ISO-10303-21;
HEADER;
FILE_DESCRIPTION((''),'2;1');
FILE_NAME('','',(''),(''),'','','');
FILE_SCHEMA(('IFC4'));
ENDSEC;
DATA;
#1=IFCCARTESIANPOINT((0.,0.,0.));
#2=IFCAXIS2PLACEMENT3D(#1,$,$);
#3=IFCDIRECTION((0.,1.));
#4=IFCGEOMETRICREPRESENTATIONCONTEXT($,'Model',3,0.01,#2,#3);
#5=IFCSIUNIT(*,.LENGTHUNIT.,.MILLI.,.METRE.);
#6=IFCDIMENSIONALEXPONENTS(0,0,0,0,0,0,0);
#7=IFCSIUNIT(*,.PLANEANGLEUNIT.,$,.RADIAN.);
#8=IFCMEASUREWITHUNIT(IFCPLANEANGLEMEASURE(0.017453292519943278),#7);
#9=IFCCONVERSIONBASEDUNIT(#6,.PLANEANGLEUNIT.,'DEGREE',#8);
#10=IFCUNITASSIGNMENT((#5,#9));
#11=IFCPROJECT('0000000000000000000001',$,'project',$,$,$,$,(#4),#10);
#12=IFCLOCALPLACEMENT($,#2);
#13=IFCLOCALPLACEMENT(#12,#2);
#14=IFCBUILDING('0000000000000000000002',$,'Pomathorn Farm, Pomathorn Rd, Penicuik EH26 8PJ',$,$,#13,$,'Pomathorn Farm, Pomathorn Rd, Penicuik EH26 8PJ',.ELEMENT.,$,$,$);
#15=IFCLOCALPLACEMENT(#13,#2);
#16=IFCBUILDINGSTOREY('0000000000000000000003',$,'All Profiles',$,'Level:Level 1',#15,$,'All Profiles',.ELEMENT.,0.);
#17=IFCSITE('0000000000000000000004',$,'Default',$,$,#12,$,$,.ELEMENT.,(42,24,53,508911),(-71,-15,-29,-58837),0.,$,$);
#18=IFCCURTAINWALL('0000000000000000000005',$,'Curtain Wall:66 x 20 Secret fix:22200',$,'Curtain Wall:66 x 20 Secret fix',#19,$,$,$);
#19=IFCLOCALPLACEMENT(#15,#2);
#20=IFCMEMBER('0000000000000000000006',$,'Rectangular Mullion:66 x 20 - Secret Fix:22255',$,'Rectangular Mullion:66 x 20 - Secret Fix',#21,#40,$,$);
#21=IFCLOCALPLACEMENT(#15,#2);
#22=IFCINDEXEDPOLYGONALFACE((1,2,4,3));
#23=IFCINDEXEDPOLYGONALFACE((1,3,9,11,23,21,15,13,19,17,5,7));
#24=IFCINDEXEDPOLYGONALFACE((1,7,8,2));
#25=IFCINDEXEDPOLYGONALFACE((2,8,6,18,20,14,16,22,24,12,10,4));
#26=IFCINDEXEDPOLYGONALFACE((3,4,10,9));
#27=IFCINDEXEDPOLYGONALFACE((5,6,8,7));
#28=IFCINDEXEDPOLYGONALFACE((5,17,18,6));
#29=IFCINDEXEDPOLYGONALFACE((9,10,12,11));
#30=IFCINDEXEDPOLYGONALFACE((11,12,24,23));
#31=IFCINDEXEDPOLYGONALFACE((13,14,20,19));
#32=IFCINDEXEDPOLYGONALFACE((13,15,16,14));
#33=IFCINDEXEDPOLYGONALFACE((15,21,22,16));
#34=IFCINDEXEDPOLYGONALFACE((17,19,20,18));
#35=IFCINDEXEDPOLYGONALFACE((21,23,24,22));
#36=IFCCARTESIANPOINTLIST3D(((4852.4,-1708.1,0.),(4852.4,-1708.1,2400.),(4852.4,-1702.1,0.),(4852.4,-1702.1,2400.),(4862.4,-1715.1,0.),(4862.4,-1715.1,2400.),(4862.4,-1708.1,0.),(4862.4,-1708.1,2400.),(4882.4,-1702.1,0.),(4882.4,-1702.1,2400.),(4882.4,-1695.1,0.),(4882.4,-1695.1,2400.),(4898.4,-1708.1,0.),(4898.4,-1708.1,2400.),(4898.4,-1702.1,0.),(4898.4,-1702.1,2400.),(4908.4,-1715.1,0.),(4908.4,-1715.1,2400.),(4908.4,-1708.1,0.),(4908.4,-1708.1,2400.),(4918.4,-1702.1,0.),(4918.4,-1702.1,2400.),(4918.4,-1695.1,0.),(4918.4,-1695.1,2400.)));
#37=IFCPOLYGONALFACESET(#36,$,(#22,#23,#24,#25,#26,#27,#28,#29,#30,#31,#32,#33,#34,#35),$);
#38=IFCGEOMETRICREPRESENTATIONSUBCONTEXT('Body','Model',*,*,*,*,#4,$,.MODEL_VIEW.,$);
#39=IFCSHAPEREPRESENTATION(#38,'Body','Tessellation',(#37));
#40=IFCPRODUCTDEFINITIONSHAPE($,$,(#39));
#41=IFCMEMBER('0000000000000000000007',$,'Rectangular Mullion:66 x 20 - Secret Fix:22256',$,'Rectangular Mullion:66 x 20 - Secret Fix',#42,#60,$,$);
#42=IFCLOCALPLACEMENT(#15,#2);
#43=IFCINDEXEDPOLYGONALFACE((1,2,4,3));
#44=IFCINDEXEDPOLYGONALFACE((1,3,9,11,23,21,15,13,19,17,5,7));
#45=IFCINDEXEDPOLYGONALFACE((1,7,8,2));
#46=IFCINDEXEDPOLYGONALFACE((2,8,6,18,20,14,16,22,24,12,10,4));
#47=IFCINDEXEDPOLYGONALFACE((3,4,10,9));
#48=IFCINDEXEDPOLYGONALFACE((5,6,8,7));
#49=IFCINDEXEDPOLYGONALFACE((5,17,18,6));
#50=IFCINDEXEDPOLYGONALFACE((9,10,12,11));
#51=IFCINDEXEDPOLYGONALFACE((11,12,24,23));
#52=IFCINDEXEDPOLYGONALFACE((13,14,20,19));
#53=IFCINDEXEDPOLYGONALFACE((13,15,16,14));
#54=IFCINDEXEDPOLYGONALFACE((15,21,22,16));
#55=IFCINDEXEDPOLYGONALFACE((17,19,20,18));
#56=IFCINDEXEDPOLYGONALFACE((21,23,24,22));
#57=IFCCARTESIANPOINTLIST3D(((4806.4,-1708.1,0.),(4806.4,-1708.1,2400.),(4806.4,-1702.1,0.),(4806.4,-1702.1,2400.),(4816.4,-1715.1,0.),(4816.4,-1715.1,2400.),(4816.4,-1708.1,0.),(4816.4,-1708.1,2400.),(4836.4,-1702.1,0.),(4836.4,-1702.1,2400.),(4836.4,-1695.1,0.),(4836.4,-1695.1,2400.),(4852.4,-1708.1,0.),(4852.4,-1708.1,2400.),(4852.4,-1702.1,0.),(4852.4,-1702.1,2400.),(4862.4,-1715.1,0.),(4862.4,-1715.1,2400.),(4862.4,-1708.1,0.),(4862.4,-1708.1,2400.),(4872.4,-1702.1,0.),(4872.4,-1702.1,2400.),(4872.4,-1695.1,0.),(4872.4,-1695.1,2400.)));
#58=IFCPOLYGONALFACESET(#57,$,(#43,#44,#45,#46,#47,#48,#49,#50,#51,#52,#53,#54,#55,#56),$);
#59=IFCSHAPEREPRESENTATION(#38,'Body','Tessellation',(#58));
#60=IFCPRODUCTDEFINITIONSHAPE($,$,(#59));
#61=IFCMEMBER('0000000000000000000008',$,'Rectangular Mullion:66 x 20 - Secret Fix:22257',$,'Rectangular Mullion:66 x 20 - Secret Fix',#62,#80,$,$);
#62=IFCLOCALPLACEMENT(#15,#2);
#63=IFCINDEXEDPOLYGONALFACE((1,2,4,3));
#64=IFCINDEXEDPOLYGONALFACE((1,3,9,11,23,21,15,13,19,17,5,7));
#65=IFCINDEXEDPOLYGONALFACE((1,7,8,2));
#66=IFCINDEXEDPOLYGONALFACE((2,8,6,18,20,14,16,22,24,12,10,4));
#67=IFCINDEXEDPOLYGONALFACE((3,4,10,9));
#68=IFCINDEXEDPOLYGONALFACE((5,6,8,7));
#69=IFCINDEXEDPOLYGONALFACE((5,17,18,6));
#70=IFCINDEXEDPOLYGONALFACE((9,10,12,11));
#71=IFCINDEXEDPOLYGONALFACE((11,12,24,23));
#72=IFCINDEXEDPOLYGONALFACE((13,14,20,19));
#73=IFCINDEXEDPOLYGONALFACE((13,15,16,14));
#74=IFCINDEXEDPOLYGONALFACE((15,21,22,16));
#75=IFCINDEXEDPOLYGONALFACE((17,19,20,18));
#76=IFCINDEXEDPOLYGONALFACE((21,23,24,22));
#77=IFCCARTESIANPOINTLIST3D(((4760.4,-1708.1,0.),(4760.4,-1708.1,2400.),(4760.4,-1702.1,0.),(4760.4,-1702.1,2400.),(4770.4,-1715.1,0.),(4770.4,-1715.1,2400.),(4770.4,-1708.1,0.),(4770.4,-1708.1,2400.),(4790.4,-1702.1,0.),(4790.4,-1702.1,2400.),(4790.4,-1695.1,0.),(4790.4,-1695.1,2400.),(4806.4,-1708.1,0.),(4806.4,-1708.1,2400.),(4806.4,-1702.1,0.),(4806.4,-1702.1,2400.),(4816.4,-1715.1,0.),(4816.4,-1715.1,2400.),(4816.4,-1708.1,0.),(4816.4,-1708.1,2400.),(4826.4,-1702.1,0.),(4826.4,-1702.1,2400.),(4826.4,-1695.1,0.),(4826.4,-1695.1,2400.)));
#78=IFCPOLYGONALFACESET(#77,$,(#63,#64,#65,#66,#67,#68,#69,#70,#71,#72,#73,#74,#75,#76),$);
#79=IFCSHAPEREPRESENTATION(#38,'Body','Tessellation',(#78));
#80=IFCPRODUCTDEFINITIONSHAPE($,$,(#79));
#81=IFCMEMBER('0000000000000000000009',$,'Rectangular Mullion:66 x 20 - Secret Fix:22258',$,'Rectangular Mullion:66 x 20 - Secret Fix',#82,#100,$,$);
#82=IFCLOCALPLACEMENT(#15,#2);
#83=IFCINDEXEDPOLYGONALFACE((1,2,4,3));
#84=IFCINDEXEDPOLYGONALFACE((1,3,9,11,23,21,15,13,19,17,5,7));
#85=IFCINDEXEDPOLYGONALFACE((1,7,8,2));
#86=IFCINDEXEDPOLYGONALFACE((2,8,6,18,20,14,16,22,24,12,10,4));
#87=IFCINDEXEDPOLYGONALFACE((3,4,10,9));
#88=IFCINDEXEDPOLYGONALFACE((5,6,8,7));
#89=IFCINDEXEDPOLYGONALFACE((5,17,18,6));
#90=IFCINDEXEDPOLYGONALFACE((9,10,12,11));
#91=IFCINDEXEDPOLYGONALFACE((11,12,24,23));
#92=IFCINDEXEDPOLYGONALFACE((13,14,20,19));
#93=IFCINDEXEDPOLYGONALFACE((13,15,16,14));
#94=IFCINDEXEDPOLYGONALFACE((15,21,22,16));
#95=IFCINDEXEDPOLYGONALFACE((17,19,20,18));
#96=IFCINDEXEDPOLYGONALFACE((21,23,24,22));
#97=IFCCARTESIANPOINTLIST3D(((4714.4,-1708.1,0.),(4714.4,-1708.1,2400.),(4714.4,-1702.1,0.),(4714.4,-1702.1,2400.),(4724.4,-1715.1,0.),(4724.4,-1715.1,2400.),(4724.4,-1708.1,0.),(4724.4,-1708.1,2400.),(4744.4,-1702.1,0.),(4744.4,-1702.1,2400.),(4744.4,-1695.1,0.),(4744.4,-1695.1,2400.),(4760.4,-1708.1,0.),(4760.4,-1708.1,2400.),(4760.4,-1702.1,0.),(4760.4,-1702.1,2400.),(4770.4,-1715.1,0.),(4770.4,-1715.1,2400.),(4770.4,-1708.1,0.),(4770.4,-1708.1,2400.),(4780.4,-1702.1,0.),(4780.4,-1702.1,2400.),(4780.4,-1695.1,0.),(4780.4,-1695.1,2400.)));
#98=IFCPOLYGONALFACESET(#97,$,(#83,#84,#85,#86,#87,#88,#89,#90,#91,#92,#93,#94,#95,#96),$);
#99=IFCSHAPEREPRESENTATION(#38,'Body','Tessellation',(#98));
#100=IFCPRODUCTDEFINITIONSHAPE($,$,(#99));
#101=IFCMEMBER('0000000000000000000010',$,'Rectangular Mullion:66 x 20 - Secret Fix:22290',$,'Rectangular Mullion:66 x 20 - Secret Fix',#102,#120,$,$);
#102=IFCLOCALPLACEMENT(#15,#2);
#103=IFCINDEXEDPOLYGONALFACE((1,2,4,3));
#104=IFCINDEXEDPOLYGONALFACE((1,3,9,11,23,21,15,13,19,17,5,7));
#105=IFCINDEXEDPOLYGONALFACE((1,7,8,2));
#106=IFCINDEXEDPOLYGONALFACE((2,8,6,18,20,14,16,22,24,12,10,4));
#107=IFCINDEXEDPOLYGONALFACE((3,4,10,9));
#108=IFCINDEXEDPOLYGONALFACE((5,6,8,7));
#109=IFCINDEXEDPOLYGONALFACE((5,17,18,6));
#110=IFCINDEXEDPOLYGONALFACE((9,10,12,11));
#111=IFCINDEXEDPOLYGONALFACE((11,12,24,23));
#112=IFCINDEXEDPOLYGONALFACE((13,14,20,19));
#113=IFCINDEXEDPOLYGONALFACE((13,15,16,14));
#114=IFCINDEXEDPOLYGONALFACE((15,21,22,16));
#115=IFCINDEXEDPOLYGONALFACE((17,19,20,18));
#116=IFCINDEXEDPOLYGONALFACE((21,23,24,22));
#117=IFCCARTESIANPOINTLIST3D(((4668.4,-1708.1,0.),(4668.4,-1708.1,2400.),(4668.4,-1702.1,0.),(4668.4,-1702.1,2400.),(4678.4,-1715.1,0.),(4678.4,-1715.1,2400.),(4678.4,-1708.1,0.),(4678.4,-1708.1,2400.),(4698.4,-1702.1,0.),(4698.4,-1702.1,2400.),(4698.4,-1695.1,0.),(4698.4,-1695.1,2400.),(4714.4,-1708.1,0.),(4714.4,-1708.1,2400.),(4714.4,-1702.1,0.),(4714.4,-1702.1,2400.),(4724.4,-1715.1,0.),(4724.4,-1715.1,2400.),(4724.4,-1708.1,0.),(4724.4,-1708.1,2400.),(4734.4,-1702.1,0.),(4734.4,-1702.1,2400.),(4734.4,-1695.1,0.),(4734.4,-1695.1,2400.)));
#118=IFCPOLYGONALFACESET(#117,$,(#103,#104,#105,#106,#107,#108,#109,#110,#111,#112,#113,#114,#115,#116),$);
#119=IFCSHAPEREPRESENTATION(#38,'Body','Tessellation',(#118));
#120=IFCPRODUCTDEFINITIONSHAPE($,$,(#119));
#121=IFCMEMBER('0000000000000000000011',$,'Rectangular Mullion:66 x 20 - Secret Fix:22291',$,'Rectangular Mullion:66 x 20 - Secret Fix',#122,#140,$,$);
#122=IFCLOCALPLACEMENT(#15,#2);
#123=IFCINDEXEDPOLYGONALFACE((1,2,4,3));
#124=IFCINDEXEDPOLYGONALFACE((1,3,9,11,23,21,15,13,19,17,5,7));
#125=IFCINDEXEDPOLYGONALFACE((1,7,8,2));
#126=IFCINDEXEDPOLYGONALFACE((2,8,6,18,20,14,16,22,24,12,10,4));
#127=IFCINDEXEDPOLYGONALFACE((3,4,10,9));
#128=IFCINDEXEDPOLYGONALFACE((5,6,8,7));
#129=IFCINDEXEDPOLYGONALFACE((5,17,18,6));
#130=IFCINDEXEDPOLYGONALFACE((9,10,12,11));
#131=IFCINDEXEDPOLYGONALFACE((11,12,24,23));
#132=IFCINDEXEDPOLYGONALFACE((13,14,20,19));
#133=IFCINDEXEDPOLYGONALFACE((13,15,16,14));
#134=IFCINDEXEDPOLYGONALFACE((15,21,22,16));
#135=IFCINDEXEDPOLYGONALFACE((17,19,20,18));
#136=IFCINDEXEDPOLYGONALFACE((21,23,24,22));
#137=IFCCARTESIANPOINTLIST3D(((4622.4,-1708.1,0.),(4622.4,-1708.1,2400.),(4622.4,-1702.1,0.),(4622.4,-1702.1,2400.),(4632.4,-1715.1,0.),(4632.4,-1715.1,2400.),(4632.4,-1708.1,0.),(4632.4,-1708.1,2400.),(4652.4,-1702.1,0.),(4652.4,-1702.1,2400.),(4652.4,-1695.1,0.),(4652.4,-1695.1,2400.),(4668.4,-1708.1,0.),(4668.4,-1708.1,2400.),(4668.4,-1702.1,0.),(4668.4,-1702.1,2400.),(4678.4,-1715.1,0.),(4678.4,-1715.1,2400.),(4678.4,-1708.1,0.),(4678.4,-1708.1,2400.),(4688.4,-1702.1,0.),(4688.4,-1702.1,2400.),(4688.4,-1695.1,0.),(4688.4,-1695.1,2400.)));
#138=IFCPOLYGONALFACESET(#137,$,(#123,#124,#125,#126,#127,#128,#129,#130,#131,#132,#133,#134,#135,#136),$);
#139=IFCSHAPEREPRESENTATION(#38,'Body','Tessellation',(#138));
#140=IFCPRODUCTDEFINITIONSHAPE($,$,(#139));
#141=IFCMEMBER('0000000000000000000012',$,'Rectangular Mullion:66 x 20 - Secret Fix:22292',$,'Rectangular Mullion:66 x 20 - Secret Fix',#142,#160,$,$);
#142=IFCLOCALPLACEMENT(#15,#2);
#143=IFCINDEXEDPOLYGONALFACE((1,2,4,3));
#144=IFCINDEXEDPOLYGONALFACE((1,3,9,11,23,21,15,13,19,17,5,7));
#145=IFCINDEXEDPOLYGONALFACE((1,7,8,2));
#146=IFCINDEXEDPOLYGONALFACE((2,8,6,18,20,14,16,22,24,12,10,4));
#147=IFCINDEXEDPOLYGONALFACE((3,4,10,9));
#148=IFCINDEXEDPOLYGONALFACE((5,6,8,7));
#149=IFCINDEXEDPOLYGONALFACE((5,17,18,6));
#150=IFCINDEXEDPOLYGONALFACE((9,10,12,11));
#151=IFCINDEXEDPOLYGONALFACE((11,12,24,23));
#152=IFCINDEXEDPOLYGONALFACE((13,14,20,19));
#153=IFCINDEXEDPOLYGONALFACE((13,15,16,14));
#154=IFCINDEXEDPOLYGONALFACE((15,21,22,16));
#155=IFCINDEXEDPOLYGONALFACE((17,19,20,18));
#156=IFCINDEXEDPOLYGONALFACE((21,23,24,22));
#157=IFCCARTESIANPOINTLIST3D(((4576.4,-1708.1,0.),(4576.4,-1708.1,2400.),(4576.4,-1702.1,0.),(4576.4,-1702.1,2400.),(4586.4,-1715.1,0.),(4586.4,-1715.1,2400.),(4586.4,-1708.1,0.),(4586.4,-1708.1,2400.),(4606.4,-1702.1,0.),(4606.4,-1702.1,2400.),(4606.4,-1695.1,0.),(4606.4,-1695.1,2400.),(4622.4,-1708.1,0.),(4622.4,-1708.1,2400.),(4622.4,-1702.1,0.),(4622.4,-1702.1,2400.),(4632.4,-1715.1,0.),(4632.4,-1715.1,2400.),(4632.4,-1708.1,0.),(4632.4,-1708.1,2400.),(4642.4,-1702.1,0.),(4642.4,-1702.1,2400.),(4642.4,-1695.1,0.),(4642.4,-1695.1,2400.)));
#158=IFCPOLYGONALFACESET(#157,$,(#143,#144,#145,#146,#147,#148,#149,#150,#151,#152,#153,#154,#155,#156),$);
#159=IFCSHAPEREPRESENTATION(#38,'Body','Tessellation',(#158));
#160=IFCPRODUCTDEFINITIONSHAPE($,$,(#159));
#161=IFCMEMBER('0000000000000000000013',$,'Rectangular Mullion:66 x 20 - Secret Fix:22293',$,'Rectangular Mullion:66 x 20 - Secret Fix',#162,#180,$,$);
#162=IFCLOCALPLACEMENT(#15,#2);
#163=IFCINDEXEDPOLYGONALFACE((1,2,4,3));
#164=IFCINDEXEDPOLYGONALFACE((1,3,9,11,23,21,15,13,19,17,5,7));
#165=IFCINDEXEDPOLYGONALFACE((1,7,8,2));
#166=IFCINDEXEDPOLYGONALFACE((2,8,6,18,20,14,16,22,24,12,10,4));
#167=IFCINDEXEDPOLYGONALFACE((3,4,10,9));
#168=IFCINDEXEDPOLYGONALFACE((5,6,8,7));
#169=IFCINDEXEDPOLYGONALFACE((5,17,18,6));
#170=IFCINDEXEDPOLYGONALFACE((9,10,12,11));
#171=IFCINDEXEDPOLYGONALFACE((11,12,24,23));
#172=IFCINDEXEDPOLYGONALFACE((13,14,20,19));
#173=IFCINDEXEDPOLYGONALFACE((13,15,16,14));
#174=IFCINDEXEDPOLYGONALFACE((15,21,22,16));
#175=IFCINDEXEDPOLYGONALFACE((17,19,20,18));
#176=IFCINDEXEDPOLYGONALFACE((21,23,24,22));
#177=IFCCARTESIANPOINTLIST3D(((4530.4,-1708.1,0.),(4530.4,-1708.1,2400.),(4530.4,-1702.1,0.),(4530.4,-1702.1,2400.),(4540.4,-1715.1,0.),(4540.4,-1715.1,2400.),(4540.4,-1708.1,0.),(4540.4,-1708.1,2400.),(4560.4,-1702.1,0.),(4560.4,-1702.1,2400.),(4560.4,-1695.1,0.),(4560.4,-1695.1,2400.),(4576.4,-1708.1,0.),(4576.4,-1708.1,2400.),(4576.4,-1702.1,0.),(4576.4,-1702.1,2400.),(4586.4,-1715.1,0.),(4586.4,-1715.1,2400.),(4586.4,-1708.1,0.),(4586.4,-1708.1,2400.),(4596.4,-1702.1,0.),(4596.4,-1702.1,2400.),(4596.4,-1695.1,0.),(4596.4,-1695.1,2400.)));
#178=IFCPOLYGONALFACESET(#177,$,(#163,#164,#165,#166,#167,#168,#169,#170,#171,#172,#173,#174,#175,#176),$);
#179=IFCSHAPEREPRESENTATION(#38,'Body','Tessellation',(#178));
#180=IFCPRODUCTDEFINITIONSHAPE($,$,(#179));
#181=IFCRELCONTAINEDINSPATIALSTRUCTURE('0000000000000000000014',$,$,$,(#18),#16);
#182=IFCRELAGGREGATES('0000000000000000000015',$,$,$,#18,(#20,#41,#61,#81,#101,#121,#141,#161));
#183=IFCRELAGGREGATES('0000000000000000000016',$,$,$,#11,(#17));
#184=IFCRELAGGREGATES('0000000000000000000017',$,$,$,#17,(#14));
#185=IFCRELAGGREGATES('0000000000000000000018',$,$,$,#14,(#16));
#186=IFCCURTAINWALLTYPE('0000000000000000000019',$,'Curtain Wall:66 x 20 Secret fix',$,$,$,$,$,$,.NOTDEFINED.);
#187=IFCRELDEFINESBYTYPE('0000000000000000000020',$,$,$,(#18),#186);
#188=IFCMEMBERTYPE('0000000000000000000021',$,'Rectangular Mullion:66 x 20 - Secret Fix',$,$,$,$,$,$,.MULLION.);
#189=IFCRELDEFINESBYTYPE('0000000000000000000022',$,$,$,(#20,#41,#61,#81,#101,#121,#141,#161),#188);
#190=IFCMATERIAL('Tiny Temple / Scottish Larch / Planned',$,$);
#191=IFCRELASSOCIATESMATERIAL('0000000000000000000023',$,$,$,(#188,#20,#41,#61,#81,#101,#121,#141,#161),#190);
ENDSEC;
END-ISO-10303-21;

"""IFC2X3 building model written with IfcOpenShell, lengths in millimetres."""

from ifc_helpers import new_model, entity, si_unit, converted_unit, direction, frame, origin, place, context, subcontext, project, spatial, polyline, outline, extrude, source, transform, mapped, material, type_object, type_shapes, element, aggregate, save


model = new_model("IFC2X3")

# Units and contexts
model_context = context("Model", 3, precision=0.01, world=origin(), true_north=direction((0.0, 1.0)))
body_context = subcontext(model_context, "Body", "Model", "MODEL_VIEW")
ifc_project = project(units=[si_unit("LENGTHUNIT", "METRE", prefix="MILLI"), converted_unit("PLANEANGLEUNIT", "DEGREE", entity("IfcPlaneAngleMeasure", 0.017453292519943278), si_unit("PLANEANGLEUNIT", "RADIAN"), dimensions=[0, 0, 0, 0, 0, 0, 0])], contexts=[model_context])

# Site, building, storey
site_placement = place(None, origin())
site = spatial("IfcSite", under=ifc_project, at=site_placement, Name="Default", CompositionType="ELEMENT", RefLatitude=(42, 24, 53, 508911), RefLongitude=(-71, -15, -29, -58837), RefElevation=0.0)
building_placement = place(site_placement, origin())
building = spatial("IfcBuilding", under=site, at=building_placement, Name="Pomathorn Farm, Pomathorn Rd, Penicuik EH26 8PJ", LongName="Pomathorn Farm, Pomathorn Rd, Penicuik EH26 8PJ", CompositionType="ELEMENT")
storey_placement = place(building_placement, origin())
storey = spatial("IfcBuildingStorey", under=building, at=storey_placement, Name="All Profiles", ObjectType="Level:Level 1", LongName="All Profiles", CompositionType="ELEMENT", Elevation=0.0)

# Curtain wall, members
curtain_wall_type = type_object("IfcCurtainWallType", Name="Curtain Wall:66 x 20 Secret fix", PredefinedType="NOTDEFINED")
curtain_wall_placement = place(storey_placement, origin())
curtain_wall = element("IfcCurtainWall", 1, at=curtain_wall_placement, inside=storey, type_object=curtain_wall_type, Name="Curtain Wall:66 x 20 Secret fix:22200", ObjectType="Curtain Wall:66 x 20 Secret fix")
ifc_material = material(Name="Tiny Temple / Scottish Larch / Planned")
member_type_1 = type_object("IfcMemberType", Name="Rectangular Mullion:66 x 20 - Secret Fix", PredefinedType="MULLION", material=ifc_material)
shared_shape_1 = source(origin(), body_context, "Body", "SweptSolid", [
    extrude(outline(polyline([(-3.0, -34.7), (3.0, -34.7), (3.0, -4.7), (10.0, -4.7), (10.0, 31.3), (3.0, 31.3), (3.0, 11.3), (-3.0, 11.3), (-3.0, 21.3), (-10.0, 21.3), (-10.0, -24.7), (-3.0, -24.7), (-3.0, -34.7)])), frame((-31.3, -10.0, -2400.0), z_axis=(0.0, 0.0, 1.0), x_axis=(0.0, -1.0, 0.0)), (0.0, 0.0, 1.0), 2400.0),
])
type_shapes(member_type_1, [shared_shape_1])
member_1_placement = place(curtain_wall_placement, frame((4918.4, -1715.1, 0.0), z_axis=(0.0, 0.0, -1.0), x_axis=(1.0, 0.0, 0.0)))
member_1 = element("IfcMember", 2, at=member_1_placement, type_object=member_type_1, material=ifc_material, Name="Rectangular Mullion:66 x 20 - Secret Fix:22255", ObjectType="Rectangular Mullion:66 x 20 - Secret Fix", context=body_context, shape_type="MappedRepresentation", body=[
    mapped(shared_shape_1, transform((0.0, 0.0, 0.0), scale=1.0)),
])
member_2_placement = place(curtain_wall_placement, frame((4872.4, -1715.1, 0.0), z_axis=(0.0, 0.0, -1.0), x_axis=(1.0, 0.0, 0.0)))
member_2 = element("IfcMember", 3, at=member_2_placement, type_object=member_type_1, material=ifc_material, Name="Rectangular Mullion:66 x 20 - Secret Fix:22256", ObjectType="Rectangular Mullion:66 x 20 - Secret Fix", context=body_context, shape_type="MappedRepresentation", body=[
    mapped(shared_shape_1, transform((0.0, 0.0, 0.0), scale=1.0)),
])
member_3_placement = place(curtain_wall_placement, frame((4826.4, -1715.1, 0.0), z_axis=(0.0, 0.0, -1.0), x_axis=(1.0, 0.0, 0.0)))
member_3 = element("IfcMember", 4, at=member_3_placement, type_object=member_type_1, material=ifc_material, Name="Rectangular Mullion:66 x 20 - Secret Fix:22257", ObjectType="Rectangular Mullion:66 x 20 - Secret Fix", context=body_context, shape_type="MappedRepresentation", body=[
    mapped(shared_shape_1, transform((0.0, 0.0, 0.0), scale=1.0)),
])
member_4_placement = place(curtain_wall_placement, frame((4780.4, -1715.1, 0.0), z_axis=(0.0, 0.0, -1.0), x_axis=(1.0, 0.0, 0.0)))
member_4 = element("IfcMember", 5, at=member_4_placement, type_object=member_type_1, material=ifc_material, Name="Rectangular Mullion:66 x 20 - Secret Fix:22258", ObjectType="Rectangular Mullion:66 x 20 - Secret Fix", context=body_context, shape_type="MappedRepresentation", body=[
    mapped(shared_shape_1, transform((0.0, 0.0, 0.0), scale=1.0)),
])
member_5_placement = place(curtain_wall_placement, frame((4734.4, -1715.1, 0.0), z_axis=(0.0, 0.0, -1.0), x_axis=(1.0, 0.0, 0.0)))
member_5 = element("IfcMember", 6, at=member_5_placement, type_object=member_type_1, material=ifc_material, Name="Rectangular Mullion:66 x 20 - Secret Fix:22290", ObjectType="Rectangular Mullion:66 x 20 - Secret Fix", context=body_context, shape_type="MappedRepresentation", body=[
    mapped(shared_shape_1, transform((0.0, 0.0, 0.0), scale=1.0)),
])
member_6_placement = place(curtain_wall_placement, frame((4688.4, -1715.1, 0.0), z_axis=(0.0, 0.0, -1.0), x_axis=(1.0, 0.0, 0.0)))
member_6 = element("IfcMember", 7, at=member_6_placement, type_object=member_type_1, material=ifc_material, Name="Rectangular Mullion:66 x 20 - Secret Fix:22291", ObjectType="Rectangular Mullion:66 x 20 - Secret Fix", context=body_context, shape_type="MappedRepresentation", body=[
    mapped(shared_shape_1, transform((0.0, 0.0, 0.0), scale=1.0)),
])
member_7_placement = place(curtain_wall_placement, frame((4642.4, -1715.1, 0.0), z_axis=(0.0, 0.0, -1.0), x_axis=(1.0, 0.0, 0.0)))
member_7 = element("IfcMember", 8, at=member_7_placement, type_object=member_type_1, material=ifc_material, Name="Rectangular Mullion:66 x 20 - Secret Fix:22292", ObjectType="Rectangular Mullion:66 x 20 - Secret Fix", context=body_context, shape_type="MappedRepresentation", body=[
    mapped(shared_shape_1, transform((0.0, 0.0, 0.0), scale=1.0)),
])
member_8_placement = place(curtain_wall_placement, frame((4596.4, -1715.1, 0.0), z_axis=(0.0, 0.0, -1.0), x_axis=(1.0, 0.0, 0.0)))
member_8 = element("IfcMember", 9, at=member_8_placement, type_object=member_type_1, material=ifc_material, Name="Rectangular Mullion:66 x 20 - Secret Fix:22293", ObjectType="Rectangular Mullion:66 x 20 - Secret Fix", context=body_context, shape_type="MappedRepresentation", body=[
    mapped(shared_shape_1, transform((0.0, 0.0, 0.0), scale=1.0)),
])
aggregate(curtain_wall, [member_1, member_2, member_3, member_4, member_5, member_6, member_7, member_8])

save(model, "model.ifc")
